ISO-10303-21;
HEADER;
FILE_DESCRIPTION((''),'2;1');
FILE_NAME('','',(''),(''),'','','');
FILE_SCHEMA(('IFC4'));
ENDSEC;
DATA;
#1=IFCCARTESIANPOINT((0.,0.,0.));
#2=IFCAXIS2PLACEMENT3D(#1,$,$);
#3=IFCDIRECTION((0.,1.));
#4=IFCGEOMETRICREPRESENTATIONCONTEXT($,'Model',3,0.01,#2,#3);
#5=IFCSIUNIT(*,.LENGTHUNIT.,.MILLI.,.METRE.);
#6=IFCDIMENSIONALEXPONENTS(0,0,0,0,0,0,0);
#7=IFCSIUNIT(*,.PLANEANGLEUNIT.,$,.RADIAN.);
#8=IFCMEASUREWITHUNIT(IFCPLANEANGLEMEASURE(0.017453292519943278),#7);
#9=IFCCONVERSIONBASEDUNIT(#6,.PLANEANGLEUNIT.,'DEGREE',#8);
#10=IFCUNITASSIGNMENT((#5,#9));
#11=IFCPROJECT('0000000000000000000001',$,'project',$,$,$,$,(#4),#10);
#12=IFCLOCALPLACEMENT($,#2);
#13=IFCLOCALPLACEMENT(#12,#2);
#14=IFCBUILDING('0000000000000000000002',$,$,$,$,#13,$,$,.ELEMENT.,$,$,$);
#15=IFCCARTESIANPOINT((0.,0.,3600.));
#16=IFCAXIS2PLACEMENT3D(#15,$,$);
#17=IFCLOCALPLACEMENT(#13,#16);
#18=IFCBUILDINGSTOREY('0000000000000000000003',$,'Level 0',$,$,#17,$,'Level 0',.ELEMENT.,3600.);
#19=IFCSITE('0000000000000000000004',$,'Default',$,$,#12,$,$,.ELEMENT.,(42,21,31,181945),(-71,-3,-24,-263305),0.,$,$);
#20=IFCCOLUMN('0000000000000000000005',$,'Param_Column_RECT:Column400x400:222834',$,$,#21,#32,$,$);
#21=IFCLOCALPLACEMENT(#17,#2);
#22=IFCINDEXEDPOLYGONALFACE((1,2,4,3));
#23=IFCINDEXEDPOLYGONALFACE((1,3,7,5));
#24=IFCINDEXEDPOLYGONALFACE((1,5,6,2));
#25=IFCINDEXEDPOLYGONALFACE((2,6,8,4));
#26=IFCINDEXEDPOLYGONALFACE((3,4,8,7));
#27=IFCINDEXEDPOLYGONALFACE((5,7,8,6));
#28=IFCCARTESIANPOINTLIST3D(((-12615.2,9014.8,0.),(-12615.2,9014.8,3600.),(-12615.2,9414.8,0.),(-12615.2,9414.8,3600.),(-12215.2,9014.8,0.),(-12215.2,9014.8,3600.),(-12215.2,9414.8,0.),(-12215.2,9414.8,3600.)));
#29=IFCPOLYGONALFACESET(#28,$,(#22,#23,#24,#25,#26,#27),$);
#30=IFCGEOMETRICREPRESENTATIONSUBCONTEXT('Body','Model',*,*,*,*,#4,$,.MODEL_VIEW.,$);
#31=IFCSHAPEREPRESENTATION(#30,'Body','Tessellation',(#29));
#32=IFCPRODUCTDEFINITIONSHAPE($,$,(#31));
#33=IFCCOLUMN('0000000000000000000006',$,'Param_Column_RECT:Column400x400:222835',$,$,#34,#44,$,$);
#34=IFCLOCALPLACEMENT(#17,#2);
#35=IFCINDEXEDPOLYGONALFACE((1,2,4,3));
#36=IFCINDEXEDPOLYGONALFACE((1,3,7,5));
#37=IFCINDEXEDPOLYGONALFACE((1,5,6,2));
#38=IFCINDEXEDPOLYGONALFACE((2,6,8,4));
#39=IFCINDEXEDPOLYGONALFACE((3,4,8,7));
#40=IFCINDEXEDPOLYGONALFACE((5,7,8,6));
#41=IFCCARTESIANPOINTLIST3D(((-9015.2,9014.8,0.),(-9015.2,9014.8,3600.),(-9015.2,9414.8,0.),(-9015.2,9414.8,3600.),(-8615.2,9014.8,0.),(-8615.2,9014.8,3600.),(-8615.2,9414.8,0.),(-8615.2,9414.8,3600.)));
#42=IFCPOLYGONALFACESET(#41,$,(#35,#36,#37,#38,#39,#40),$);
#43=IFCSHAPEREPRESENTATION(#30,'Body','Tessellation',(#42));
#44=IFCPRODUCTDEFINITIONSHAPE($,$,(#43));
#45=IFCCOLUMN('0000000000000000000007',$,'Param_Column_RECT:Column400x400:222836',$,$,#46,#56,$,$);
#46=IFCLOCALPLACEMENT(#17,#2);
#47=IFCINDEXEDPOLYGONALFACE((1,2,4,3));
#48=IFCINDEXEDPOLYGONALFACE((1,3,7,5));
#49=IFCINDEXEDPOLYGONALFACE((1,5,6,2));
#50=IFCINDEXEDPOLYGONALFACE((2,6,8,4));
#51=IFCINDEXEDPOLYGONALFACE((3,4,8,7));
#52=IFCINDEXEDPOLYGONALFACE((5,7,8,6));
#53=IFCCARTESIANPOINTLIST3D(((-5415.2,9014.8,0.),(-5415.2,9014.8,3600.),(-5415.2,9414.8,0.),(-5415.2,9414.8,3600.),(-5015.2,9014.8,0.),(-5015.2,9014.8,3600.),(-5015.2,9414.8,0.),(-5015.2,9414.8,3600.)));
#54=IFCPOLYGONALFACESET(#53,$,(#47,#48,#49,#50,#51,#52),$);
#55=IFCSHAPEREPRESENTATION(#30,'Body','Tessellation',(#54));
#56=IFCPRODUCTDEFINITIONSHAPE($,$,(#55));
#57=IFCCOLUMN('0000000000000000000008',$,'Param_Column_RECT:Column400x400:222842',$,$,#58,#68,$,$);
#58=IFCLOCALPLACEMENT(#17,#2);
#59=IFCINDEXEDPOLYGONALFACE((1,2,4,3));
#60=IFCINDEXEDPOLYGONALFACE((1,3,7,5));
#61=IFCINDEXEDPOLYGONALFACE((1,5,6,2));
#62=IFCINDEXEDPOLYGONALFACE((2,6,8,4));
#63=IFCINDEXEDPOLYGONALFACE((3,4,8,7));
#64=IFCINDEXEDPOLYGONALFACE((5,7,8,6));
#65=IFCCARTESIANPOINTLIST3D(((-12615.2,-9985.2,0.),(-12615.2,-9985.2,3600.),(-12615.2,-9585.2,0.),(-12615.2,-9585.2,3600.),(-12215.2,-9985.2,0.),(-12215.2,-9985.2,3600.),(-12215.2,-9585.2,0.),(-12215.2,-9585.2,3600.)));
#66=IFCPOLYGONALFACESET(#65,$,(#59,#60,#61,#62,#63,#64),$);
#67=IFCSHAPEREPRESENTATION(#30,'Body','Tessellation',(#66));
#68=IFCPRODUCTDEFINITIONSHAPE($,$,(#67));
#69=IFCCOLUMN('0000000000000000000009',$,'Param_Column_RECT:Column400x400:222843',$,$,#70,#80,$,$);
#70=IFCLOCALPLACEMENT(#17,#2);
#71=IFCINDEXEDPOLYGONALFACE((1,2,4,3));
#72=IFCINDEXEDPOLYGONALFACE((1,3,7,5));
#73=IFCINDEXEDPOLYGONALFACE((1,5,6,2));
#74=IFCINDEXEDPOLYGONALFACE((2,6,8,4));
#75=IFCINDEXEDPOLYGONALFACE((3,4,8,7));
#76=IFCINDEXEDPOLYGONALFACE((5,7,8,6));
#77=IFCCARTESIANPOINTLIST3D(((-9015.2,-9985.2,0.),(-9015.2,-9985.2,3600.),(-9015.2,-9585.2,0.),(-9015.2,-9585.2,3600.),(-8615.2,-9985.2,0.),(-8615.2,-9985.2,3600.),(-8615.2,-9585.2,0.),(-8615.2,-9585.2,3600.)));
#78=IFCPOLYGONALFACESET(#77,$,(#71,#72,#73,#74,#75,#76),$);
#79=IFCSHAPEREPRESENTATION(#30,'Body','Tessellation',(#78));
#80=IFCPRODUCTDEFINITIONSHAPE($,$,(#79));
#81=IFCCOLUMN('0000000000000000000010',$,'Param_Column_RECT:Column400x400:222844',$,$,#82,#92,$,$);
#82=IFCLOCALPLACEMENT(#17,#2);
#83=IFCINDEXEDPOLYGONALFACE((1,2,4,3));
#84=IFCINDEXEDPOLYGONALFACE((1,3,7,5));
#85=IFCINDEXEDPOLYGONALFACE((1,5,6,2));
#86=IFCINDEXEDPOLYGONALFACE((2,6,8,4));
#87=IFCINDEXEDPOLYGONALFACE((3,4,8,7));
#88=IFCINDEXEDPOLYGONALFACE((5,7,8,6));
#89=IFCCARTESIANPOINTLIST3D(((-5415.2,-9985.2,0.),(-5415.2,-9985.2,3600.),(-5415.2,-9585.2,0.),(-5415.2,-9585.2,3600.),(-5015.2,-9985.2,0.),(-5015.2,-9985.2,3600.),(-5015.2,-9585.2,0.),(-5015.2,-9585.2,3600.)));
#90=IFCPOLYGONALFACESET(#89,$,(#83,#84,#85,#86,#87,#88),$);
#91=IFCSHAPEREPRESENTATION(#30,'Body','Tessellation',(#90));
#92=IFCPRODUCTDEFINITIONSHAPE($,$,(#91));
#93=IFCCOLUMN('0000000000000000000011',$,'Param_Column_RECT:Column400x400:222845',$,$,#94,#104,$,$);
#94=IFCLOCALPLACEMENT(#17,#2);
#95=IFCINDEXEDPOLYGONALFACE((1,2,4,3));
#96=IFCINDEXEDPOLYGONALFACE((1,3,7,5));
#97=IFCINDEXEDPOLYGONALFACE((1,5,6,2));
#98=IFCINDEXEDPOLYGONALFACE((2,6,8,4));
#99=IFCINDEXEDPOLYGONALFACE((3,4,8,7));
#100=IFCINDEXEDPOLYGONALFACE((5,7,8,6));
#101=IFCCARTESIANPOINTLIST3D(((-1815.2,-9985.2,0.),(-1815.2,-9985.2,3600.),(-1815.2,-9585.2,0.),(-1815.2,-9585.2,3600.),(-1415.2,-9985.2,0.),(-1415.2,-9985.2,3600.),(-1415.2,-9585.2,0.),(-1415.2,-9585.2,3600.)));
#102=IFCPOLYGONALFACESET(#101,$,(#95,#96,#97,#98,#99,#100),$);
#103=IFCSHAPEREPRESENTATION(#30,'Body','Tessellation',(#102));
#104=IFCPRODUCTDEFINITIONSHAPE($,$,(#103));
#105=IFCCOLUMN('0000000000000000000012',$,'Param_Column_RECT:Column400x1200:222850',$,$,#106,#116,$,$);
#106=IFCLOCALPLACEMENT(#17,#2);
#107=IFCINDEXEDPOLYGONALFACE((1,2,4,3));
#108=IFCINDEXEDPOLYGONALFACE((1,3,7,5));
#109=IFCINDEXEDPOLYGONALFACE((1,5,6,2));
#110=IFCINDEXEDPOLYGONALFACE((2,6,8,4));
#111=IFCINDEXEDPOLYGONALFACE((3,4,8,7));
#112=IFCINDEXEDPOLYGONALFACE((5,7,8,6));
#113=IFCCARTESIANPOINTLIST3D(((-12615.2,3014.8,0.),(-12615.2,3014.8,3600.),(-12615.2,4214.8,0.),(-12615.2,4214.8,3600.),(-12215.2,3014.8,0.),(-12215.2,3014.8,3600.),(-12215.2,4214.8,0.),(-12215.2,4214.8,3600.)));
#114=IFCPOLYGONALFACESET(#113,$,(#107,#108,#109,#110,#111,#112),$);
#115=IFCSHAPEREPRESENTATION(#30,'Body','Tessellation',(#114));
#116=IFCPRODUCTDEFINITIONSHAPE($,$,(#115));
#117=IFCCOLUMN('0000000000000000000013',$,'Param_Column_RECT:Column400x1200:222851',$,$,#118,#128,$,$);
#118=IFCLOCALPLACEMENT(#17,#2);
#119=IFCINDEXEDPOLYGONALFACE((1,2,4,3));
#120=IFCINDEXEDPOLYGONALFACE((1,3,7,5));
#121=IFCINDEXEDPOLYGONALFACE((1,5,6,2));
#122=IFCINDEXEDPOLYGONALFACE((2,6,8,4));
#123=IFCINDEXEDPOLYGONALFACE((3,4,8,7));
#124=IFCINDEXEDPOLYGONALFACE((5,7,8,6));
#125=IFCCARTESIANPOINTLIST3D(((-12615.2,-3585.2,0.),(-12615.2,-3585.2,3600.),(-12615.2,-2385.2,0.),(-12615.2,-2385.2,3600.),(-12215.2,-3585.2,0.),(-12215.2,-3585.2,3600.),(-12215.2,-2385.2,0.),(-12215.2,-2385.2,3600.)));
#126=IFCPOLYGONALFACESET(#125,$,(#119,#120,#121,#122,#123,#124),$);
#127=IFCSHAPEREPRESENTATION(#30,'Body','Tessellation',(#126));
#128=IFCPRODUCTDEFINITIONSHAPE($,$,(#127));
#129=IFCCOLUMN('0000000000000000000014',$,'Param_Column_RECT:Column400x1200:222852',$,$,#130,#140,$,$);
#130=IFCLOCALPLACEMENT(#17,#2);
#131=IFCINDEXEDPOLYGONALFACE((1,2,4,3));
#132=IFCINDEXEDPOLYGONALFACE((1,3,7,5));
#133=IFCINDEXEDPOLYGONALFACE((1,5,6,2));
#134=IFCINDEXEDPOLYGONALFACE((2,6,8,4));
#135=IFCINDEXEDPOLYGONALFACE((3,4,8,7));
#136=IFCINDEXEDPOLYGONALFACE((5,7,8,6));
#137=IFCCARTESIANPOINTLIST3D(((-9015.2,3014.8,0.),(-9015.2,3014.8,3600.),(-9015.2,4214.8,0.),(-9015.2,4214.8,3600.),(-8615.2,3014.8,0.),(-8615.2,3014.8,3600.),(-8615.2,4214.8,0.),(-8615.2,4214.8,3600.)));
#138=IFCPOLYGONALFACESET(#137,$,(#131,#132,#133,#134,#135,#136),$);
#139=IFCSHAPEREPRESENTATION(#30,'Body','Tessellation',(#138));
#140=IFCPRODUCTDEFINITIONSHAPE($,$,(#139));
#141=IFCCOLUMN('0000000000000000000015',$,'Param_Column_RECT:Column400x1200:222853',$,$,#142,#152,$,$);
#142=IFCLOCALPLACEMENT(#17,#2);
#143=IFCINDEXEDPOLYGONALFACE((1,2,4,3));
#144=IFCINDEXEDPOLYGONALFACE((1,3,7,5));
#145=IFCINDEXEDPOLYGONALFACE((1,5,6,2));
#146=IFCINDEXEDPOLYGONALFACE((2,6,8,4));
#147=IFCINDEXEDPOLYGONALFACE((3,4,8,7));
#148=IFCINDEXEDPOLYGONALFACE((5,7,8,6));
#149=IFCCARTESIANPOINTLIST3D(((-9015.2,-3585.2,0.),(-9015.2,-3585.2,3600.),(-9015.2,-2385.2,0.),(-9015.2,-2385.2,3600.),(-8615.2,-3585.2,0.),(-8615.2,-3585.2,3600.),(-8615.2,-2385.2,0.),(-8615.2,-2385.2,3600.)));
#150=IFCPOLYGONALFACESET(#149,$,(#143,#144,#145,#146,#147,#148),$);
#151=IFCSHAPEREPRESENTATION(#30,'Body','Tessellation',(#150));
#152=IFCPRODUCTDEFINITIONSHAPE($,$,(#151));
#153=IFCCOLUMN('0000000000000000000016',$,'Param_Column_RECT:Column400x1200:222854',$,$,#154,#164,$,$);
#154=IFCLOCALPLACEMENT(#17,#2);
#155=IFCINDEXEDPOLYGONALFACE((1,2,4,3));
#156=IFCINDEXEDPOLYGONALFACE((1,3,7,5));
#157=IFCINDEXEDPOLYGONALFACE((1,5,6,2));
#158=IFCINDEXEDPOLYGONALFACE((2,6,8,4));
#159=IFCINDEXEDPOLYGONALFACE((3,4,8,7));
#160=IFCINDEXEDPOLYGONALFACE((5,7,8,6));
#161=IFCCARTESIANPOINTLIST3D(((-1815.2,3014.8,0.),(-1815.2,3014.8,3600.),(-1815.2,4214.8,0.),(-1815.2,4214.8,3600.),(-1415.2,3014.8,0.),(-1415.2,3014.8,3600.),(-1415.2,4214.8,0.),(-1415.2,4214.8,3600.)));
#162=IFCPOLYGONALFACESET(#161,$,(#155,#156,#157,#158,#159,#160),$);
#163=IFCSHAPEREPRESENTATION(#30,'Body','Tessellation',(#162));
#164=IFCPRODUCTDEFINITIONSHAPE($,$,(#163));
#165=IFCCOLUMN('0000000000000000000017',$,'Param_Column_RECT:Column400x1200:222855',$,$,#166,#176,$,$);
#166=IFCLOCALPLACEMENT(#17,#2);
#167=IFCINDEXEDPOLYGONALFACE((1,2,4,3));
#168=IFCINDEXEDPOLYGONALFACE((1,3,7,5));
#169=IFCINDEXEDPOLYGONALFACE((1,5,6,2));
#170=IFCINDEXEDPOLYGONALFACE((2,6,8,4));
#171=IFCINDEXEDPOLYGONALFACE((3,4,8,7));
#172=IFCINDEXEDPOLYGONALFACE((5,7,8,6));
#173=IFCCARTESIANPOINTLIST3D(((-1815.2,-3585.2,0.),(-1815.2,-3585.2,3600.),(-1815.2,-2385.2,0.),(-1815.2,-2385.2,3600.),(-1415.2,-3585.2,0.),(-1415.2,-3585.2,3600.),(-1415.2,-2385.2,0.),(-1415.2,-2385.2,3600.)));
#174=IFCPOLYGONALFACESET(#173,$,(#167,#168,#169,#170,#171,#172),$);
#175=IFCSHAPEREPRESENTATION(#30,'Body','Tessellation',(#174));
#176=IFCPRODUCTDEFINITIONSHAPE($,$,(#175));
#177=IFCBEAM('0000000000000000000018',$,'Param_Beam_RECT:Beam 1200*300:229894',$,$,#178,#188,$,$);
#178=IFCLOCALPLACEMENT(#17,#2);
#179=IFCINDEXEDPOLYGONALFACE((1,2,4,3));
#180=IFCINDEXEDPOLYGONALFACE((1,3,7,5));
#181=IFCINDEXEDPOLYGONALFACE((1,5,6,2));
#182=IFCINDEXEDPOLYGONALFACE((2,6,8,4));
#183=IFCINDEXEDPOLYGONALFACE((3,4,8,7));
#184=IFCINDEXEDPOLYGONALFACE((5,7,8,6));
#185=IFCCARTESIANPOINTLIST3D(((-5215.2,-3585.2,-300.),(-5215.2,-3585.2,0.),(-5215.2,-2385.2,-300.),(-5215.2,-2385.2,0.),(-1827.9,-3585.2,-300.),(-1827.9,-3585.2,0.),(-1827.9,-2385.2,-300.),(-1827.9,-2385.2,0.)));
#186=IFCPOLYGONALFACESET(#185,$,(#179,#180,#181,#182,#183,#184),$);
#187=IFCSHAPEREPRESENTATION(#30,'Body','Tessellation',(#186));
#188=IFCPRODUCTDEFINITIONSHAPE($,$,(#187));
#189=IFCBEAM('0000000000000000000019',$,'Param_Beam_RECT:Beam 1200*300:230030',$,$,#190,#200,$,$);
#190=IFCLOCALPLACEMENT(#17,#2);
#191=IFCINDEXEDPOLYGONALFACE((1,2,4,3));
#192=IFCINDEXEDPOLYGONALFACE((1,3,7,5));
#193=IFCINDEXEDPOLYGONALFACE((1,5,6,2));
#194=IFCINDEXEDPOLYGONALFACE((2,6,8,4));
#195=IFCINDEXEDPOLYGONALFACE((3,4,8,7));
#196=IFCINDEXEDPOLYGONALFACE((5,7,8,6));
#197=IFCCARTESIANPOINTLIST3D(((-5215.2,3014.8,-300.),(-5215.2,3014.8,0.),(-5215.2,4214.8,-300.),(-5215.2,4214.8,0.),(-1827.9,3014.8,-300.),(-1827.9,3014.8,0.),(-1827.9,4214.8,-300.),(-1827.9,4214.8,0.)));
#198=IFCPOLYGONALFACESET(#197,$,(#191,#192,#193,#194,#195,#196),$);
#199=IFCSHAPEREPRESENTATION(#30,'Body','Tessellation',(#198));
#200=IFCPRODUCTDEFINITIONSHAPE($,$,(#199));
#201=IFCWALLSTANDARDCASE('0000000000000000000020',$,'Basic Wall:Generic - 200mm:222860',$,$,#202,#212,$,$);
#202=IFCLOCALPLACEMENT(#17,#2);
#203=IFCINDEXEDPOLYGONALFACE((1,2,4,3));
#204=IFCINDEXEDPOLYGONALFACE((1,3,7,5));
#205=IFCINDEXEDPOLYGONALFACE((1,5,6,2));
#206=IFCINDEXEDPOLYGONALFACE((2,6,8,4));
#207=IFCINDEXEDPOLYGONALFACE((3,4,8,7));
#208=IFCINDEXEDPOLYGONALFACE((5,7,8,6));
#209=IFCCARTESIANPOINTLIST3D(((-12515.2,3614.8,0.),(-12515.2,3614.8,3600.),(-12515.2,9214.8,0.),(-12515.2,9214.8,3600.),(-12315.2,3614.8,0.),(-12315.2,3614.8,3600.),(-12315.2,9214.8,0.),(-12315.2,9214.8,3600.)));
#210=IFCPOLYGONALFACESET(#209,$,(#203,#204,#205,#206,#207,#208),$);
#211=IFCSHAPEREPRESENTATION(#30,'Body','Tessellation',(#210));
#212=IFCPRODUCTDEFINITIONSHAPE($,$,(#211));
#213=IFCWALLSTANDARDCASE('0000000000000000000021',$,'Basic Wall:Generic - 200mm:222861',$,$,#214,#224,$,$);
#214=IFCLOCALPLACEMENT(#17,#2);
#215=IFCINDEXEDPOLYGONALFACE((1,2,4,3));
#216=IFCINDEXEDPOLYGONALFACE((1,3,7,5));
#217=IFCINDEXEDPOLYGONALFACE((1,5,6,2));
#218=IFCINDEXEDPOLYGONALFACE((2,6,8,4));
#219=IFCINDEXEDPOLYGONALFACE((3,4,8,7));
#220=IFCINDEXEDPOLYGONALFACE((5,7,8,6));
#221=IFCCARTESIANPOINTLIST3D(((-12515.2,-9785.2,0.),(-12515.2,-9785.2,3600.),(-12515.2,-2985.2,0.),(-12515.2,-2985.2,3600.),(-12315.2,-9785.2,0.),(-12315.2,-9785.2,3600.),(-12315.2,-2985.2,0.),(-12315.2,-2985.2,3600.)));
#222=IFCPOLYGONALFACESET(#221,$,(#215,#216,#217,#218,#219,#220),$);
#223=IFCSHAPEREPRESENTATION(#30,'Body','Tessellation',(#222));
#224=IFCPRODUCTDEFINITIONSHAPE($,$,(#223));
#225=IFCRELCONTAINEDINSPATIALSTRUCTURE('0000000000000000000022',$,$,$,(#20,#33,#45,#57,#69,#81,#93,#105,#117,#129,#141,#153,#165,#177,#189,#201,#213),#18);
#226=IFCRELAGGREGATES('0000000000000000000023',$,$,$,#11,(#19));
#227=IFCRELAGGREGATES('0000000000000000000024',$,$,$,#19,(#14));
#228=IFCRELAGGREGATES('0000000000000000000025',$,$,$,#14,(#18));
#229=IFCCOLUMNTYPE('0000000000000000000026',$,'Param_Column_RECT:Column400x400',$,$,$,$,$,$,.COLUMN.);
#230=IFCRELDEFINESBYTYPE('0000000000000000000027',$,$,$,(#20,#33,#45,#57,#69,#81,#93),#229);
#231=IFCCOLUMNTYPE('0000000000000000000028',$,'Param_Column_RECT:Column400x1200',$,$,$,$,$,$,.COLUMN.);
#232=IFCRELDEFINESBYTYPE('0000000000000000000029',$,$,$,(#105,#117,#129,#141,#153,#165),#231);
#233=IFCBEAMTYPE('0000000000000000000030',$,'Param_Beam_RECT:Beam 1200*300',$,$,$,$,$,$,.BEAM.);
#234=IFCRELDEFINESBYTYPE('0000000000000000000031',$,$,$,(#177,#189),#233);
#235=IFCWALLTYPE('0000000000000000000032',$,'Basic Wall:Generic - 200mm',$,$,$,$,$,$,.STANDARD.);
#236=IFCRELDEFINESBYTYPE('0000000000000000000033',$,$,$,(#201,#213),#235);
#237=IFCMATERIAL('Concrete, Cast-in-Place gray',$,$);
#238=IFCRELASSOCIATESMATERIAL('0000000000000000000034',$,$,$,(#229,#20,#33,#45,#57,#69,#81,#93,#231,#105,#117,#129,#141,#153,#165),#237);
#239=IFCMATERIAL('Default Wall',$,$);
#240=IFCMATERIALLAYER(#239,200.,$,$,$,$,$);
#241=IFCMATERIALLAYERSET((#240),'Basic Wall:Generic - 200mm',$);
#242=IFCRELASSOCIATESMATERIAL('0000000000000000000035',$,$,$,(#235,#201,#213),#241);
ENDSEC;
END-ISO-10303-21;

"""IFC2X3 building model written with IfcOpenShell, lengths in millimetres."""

from ifc_helpers import new_model, entity, si_unit, converted_unit, direction, frame, frame_2d, origin, origin_2d_with_axis, place, context, subcontext, project, spatial, rectangle, extrude, source, transform, mapped, material, layer, layer_set, layer_usage, type_object, type_shapes, element, save


model = new_model("IFC2X3")

# Units and contexts
model_context = context("Model", 3, precision=0.01, world=origin(), true_north=direction((0.0, 1.0)))
body_context = subcontext(model_context, "Body", "Model", "MODEL_VIEW")
ifc_project = project(units=[si_unit("LENGTHUNIT", "METRE", prefix="MILLI"), converted_unit("PLANEANGLEUNIT", "DEGREE", entity("IfcPlaneAngleMeasure", 0.017453292519943278), si_unit("PLANEANGLEUNIT", "RADIAN"), dimensions=[0, 0, 0, 0, 0, 0, 0])], contexts=[model_context])

# Site, building, storey
site_placement = place(None, origin())
site = spatial("IfcSite", under=ifc_project, at=site_placement, Name="Default", CompositionType="ELEMENT", RefLatitude=(42, 21, 31, 181945), RefLongitude=(-71, -3, -24, -263305), RefElevation=0.0)
building_placement = place(site_placement, origin())
building = spatial("IfcBuilding", under=site, at=building_placement, CompositionType="ELEMENT")
storey_placement = place(building_placement, frame((0.0, 0.0, 3600.0)))
storey = spatial("IfcBuildingStorey", under=building, at=storey_placement, Name="Level 0", LongName="Level 0", CompositionType="ELEMENT", Elevation=3600.0)

# Columns
ifc_material_1 = material(Name="Concrete, Cast-in-Place gray")
column_type_1 = type_object("IfcColumnType", Name="Param_Column_RECT:Column400x400", PredefinedType="COLUMN", material=ifc_material_1)
shared_shape_1 = source(origin(), body_context, "Body", "SweptSolid", [
    extrude(rectangle(XDim=400.0, YDim=400.0, at=origin_2d_with_axis()), frame((0.0, 0.0, 3600.0), z_axis=(0.0, 0.0, 1.0), x_axis=(-1.0, 0.0, 0.0)), (0.0, 0.0, 1.0), 3600.0),
])
type_shapes(column_type_1, [shared_shape_1])
for number, where, name in (
    (1, (-12415.2, 9214.8, -3600.0), "Param_Column_RECT:Column400x400:222834"),
    (2, (-8815.2, 9214.8, -3600.0), "Param_Column_RECT:Column400x400:222835"),
    (3, (-5215.2, 9214.8, -3600.0), "Param_Column_RECT:Column400x400:222836"),
    (4, (-12415.2, -9785.2, -3600.0), "Param_Column_RECT:Column400x400:222842"),
    (5, (-8815.2, -9785.2, -3600.0), "Param_Column_RECT:Column400x400:222843"),
    (6, (-5215.2, -9785.2, -3600.0), "Param_Column_RECT:Column400x400:222844"),
    (7, (-1615.2, -9785.2, -3600.0), "Param_Column_RECT:Column400x400:222845"),
):
    element("IfcColumn", number, at=place(storey_placement, frame(where)), inside=storey, type_object=column_type_1, material=ifc_material_1, Name=name, context=body_context, shape_type="MappedRepresentation", body=[
        mapped(shared_shape_1, transform((0.0, 0.0, 0.0), scale=1.0)),
    ])
column_type_2 = type_object("IfcColumnType", Name="Param_Column_RECT:Column400x1200", PredefinedType="COLUMN", material=ifc_material_1)
shared_shape_2 = source(origin(), body_context, "Body", "SweptSolid", [
    extrude(rectangle(XDim=400.0, YDim=1200.0, at=origin_2d_with_axis()), frame((0.0, 0.0, 3600.0), z_axis=(0.0, 0.0, 1.0), x_axis=(-1.0, 0.0, 0.0)), (0.0, 0.0, 1.0), 3600.0),
])
type_shapes(column_type_2, [shared_shape_2])
for number, where, name in (
    (8, (-12415.2, 3614.8, -3600.0), "Param_Column_RECT:Column400x1200:222850"),
    (9, (-12415.2, -2985.2, -3600.0), "Param_Column_RECT:Column400x1200:222851"),
    (10, (-8815.2, 3614.8, -3600.0), "Param_Column_RECT:Column400x1200:222852"),
    (11, (-8815.2, -2985.2, -3600.0), "Param_Column_RECT:Column400x1200:222853"),
    (12, (-1615.2, 3614.8, -3600.0), "Param_Column_RECT:Column400x1200:222854"),
    (13, (-1615.2, -2985.2, -3600.0), "Param_Column_RECT:Column400x1200:222855"),
):
    element("IfcColumn", number, at=place(storey_placement, frame(where)), inside=storey, type_object=column_type_2, material=ifc_material_1, Name=name, context=body_context, shape_type="MappedRepresentation", body=[
        mapped(shared_shape_2, transform((0.0, 0.0, 0.0), scale=1.0)),
    ])

# Beams
beam_type_1 = type_object("IfcBeamType", Name="Param_Beam_RECT:Beam 1200*300", PredefinedType="BEAM")
beam_1_placement = place(storey_placement, frame((-5215.2, -2985.2, 0.0)))
element("IfcBeam", 14, at=beam_1_placement, inside=storey, type_object=beam_type_1, Name="Param_Beam_RECT:Beam 1200*300:229894", context=body_context, shape_type="SweptSolid", body=[
    extrude(rectangle(XDim=300.0, YDim=1200.0, at=frame_2d((0.0, 0.0), x_axis=(1.0, 0.0))), frame((0.0, 0.0, -150.0), z_axis=(1.0, 0.0, 0.0), x_axis=(0.0, 0.0, -1.0)), (0.0, 0.0, 1.0), 3387.3),
])
beam_2_placement = place(storey_placement, frame((-5215.2, 3614.8, 0.0)))
element("IfcBeam", 15, at=beam_2_placement, inside=storey, type_object=beam_type_1, Name="Param_Beam_RECT:Beam 1200*300:230030", context=body_context, shape_type="SweptSolid", body=[
    extrude(rectangle(XDim=300.0, YDim=1200.0, at=frame_2d((0.0, 0.0), x_axis=(1.0, 0.0))), frame((0.0, 0.0, -150.0), z_axis=(1.0, 0.0, 0.0), x_axis=(0.0, 0.0, -1.0)), (0.0, 0.0, 1.0), 3387.3),
])

# Walls
ifc_material_2 = material(Name="Default Wall")
ifc_layer = layer(ifc_material_2, 200.0)
ifc_layer_set = layer_set([ifc_layer], Name="Basic Wall:Generic - 200mm")
ifc_layer_usage_1 = layer_usage(ifc_layer_set, "AXIS2", "NEGATIVE", 100.0)
wall_type = type_object("IfcWallType", Name="Basic Wall:Generic - 200mm", PredefinedType="STANDARD", material=ifc_layer_set)
wall_1_placement = place(storey_placement, frame((-12415.2, 3614.8, 0.0), z_axis=(0.0, 0.0, 1.0), x_axis=(0.0, 1.0, 0.0)))
element("IfcWallStandardCase", 16, at=wall_1_placement, inside=storey, type_object=wall_type, material=ifc_layer_usage_1, Name="Basic Wall:Generic - 200mm:222860", context=body_context, shape_type="SweptSolid", body=[
    extrude(rectangle(XDim=5600.0, YDim=200.0, at=frame_2d((2800.0, 0.0), x_axis=(-1.0, 0.0))), origin(), (0.0, 0.0, 1.0), 3600.0),
])
ifc_layer_usage_2 = layer_usage(ifc_layer_set, "AXIS2", "NEGATIVE", 100.0)
wall_2_placement = place(storey_placement, frame((-12415.2, -9785.2, 0.0), z_axis=(0.0, 0.0, 1.0), x_axis=(0.0, 1.0, 0.0)))
element("IfcWallStandardCase", 17, at=wall_2_placement, inside=storey, type_object=wall_type, material=ifc_layer_usage_2, Name="Basic Wall:Generic - 200mm:222861", context=body_context, shape_type="SweptSolid", body=[
    extrude(rectangle(XDim=6800.0, YDim=200.0, at=frame_2d((3400.0, 0.0), x_axis=(-1.0, 0.0))), origin(), (0.0, 0.0, 1.0), 3600.0),
])

save(model, "model.ifc")
